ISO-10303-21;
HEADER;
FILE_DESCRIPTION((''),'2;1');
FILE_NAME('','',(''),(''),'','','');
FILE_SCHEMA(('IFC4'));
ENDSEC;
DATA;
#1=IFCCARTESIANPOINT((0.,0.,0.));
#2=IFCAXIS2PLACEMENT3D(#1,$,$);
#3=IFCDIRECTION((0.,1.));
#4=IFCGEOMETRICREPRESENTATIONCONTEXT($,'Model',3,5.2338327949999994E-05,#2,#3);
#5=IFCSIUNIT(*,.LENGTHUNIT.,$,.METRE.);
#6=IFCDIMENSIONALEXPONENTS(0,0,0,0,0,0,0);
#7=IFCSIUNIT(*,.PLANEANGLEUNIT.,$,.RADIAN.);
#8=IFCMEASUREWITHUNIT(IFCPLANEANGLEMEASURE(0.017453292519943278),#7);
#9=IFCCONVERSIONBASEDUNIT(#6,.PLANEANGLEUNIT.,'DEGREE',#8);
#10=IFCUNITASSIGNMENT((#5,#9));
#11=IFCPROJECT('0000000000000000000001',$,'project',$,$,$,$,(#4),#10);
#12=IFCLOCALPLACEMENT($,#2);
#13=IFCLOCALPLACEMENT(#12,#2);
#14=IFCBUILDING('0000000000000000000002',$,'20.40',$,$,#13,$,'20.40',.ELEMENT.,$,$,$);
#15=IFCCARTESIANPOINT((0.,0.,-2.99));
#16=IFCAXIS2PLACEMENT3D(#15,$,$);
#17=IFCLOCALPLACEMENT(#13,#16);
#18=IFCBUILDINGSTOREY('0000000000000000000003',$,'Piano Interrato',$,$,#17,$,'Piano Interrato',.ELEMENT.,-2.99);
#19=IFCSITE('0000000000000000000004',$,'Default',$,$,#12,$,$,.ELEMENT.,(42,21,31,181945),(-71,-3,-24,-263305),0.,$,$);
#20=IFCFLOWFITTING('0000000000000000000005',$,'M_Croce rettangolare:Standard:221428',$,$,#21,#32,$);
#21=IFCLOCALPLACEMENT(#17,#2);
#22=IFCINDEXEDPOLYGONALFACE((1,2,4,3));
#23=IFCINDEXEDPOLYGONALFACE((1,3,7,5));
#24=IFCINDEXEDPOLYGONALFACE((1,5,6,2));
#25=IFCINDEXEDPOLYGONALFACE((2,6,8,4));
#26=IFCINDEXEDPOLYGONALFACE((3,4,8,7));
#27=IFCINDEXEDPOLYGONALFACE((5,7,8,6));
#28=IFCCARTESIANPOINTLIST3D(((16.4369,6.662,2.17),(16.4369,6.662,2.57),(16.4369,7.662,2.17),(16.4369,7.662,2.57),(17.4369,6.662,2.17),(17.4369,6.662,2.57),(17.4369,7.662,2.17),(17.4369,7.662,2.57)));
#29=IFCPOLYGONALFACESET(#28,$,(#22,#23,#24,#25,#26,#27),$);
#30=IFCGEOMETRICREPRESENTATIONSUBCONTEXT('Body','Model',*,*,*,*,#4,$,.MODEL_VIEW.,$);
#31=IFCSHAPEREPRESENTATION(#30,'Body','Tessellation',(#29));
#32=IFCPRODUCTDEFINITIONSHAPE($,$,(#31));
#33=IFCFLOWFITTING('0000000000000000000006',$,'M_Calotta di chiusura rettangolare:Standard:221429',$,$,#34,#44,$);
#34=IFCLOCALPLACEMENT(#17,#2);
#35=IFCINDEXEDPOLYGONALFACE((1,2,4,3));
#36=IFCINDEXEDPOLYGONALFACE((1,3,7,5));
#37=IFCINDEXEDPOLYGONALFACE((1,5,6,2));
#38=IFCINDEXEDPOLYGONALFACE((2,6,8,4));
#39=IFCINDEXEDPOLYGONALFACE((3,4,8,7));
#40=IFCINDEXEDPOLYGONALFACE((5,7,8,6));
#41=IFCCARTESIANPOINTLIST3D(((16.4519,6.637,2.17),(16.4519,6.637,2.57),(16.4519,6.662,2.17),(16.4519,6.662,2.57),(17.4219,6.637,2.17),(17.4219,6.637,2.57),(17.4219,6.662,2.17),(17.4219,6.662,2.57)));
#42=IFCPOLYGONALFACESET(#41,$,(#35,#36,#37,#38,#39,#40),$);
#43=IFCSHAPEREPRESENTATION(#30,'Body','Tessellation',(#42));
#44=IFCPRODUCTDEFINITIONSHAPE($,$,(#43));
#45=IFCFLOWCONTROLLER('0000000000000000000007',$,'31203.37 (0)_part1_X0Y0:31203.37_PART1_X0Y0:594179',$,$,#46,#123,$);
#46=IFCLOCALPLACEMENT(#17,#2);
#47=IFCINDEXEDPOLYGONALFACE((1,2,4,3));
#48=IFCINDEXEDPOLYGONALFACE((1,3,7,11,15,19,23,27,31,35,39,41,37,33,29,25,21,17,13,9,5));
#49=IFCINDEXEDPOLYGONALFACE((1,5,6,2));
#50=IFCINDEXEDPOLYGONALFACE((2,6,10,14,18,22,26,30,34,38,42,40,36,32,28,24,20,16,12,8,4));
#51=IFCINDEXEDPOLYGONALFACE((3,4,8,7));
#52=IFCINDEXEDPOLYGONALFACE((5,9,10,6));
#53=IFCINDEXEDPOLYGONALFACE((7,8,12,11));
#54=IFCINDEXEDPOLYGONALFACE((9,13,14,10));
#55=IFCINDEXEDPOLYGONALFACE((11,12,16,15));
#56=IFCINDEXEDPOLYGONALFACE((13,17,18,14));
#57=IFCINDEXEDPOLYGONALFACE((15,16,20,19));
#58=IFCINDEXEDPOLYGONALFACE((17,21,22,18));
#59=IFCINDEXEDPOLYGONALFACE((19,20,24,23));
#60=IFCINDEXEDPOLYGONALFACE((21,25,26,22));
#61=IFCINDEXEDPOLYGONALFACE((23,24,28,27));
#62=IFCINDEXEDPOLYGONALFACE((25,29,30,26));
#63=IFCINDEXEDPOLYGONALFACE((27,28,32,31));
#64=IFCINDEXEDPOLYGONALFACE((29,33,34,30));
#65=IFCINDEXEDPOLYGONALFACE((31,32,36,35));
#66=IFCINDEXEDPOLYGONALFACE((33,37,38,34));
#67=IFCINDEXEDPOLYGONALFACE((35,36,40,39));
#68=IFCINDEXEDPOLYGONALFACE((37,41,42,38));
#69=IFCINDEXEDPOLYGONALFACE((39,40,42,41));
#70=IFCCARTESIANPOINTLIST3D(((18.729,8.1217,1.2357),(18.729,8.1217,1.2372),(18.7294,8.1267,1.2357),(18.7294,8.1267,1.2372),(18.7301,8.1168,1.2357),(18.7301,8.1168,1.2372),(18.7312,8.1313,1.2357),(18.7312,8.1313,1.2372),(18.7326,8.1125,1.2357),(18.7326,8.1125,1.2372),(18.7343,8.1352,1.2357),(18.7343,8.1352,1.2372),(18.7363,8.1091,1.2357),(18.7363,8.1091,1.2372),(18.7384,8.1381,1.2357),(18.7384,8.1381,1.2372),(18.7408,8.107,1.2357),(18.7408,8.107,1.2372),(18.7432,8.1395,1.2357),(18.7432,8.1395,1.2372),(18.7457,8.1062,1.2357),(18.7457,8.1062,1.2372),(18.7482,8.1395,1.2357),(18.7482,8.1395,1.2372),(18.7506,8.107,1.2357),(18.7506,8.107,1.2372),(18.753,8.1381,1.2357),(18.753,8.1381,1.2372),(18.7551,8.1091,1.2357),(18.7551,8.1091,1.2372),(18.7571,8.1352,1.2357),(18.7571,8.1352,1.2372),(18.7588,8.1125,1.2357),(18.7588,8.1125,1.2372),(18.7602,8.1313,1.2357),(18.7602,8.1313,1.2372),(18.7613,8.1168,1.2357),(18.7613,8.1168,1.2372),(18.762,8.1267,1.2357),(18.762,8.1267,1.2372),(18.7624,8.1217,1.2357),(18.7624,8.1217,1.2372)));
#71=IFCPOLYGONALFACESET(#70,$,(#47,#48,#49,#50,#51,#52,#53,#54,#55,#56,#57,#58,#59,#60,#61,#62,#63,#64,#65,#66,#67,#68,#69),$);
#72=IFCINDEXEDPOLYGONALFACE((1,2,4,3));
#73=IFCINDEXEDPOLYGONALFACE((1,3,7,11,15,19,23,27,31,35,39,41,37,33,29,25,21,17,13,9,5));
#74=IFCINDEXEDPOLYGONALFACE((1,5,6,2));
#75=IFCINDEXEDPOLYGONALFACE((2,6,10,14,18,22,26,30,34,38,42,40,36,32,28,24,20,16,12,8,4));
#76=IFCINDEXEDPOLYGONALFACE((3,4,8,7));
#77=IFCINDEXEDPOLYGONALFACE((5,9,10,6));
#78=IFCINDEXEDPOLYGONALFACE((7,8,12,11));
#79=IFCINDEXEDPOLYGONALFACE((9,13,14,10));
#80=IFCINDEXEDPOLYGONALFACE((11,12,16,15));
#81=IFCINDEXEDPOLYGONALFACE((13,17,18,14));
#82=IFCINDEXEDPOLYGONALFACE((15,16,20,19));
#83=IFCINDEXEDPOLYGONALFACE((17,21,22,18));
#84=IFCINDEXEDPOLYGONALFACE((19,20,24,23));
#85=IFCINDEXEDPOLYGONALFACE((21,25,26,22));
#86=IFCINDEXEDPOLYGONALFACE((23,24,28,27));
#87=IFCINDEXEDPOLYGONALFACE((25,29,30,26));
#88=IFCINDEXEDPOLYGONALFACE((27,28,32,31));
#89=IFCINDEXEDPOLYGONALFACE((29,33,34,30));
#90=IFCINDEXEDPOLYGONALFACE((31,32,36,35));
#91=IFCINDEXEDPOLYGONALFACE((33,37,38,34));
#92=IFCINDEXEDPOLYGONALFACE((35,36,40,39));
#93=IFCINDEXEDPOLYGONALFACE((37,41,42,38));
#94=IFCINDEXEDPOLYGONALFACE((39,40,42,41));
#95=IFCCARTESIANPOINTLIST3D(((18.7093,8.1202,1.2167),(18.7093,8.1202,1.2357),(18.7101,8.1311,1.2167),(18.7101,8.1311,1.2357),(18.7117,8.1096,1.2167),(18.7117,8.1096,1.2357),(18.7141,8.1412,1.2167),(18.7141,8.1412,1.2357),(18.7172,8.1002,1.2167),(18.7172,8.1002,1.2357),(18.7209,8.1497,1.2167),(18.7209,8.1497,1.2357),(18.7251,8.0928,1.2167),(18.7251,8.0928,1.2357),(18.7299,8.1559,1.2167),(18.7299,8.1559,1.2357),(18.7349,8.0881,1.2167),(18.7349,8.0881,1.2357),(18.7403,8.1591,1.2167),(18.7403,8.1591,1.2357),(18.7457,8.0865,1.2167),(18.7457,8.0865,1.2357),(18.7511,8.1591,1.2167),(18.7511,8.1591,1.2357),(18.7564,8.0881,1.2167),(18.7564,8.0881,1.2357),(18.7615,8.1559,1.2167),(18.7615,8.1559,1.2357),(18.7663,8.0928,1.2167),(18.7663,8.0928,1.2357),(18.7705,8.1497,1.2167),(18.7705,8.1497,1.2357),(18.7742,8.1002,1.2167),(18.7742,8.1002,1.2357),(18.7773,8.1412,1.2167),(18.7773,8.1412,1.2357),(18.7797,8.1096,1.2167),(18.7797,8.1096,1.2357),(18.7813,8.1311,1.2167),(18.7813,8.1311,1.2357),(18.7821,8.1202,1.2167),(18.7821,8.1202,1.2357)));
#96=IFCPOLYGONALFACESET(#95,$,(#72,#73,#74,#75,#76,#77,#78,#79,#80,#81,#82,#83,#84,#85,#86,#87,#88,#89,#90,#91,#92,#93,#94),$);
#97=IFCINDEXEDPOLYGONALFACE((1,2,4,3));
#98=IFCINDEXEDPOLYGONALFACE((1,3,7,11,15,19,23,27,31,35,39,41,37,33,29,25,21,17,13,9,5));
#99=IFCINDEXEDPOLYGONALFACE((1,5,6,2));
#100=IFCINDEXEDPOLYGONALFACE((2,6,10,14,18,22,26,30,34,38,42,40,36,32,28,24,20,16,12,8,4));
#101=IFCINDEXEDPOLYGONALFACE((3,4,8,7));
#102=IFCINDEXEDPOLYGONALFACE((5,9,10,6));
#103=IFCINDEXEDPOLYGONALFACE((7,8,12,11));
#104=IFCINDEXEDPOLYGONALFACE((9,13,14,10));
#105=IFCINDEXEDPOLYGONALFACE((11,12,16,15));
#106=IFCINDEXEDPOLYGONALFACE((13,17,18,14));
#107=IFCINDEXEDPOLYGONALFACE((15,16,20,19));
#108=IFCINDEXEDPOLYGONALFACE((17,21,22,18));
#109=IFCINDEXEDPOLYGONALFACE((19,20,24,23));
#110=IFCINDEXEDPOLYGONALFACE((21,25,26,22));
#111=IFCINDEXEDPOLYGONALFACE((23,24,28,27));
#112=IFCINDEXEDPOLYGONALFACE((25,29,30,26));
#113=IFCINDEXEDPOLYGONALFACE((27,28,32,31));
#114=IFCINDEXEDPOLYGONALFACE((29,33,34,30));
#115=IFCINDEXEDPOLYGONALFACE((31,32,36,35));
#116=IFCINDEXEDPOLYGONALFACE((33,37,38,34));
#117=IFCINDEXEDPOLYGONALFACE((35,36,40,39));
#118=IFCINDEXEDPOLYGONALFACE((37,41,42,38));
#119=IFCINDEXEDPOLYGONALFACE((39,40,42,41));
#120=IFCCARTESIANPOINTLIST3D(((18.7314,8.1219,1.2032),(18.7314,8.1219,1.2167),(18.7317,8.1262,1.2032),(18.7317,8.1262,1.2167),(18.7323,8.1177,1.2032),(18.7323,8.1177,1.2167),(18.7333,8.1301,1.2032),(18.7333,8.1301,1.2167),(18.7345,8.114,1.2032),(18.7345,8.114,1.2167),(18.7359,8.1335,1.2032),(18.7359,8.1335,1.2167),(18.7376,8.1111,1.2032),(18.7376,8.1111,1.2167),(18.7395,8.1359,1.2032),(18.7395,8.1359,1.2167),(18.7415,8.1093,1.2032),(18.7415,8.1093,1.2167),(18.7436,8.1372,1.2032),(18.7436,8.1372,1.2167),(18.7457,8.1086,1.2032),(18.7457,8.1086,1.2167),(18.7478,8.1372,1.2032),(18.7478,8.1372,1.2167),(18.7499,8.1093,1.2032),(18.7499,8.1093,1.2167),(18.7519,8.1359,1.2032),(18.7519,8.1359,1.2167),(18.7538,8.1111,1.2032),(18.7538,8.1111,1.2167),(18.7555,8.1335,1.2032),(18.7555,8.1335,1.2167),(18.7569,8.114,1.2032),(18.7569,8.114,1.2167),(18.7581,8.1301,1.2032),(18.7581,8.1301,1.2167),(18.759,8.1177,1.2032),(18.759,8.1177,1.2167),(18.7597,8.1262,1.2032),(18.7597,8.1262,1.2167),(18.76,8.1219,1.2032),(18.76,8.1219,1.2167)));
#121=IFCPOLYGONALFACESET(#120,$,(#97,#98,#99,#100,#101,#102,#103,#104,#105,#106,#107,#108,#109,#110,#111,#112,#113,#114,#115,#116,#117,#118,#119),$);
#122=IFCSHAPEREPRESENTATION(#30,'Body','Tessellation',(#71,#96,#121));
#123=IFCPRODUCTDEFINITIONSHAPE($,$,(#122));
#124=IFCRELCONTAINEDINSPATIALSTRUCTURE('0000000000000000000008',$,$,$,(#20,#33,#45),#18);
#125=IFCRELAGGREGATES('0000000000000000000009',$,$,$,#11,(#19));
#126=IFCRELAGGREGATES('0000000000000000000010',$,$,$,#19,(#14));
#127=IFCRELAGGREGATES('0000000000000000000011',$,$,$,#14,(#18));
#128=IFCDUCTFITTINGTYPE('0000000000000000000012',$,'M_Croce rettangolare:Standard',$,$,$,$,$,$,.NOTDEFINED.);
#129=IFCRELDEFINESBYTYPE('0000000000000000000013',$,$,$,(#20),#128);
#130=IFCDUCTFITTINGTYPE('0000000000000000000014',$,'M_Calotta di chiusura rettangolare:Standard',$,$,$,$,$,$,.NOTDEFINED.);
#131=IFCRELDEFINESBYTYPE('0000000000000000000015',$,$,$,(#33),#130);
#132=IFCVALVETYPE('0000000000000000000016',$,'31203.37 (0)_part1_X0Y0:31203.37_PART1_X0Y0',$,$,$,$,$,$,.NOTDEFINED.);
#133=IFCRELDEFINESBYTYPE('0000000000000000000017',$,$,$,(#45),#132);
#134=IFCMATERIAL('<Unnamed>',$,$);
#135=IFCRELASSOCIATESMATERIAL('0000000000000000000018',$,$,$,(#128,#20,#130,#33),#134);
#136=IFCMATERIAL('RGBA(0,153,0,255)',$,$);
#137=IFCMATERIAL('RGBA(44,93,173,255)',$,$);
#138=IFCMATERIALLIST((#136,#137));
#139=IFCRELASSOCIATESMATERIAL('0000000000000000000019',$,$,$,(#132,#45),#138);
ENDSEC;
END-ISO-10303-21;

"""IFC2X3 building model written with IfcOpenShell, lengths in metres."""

from ifc_helpers import new_model, entity, si_unit, converted_unit, direction, frame, frame_2d, origin, place, context, subcontext, project, spatial, rectangle, circle, extrude, source, transform, mapped, material, material_list, type_object, type_shapes, element, save


model = new_model("IFC2X3")

# Units and contexts
model_context = context("Model", 3, precision=5.2338327949999994e-05, world=origin(), true_north=direction((0.0, 1.0)))
body_context = subcontext(model_context, "Body", "Model", "MODEL_VIEW")
ifc_project = project(units=[si_unit("LENGTHUNIT", "METRE"), converted_unit("PLANEANGLEUNIT", "DEGREE", entity("IfcPlaneAngleMeasure", 0.017453292519943278), si_unit("PLANEANGLEUNIT", "RADIAN"), dimensions=[0, 0, 0, 0, 0, 0, 0])], contexts=[model_context])

# Site, building, storey
site_placement = place(None, origin())
site = spatial("IfcSite", under=ifc_project, at=site_placement, Name="Default", CompositionType="ELEMENT", RefLatitude=(42, 21, 31, 181945), RefLongitude=(-71, -3, -24, -263305), RefElevation=0.0)
building_placement = place(site_placement, origin())
building = spatial("IfcBuilding", under=site, at=building_placement, Name="20.40", LongName="20.40", CompositionType="ELEMENT")
storey_placement = place(building_placement, frame((0.0, 0.0, -2.99)))
storey = spatial("IfcBuildingStorey", under=building, at=storey_placement, Name="Piano Interrato", LongName="Piano Interrato", CompositionType="ELEMENT", Elevation=-2.99)

# Flow fittings
ifc_material_1 = material(Name="<Unnamed>")
duct_fitting_type_1 = type_object("IfcDuctFittingType", Name="M_Croce rettangolare:Standard", PredefinedType="NOTDEFINED", material=ifc_material_1)
shared_shape_1 = source(origin(), body_context, "Body", "SweptSolid", [
    extrude(rectangle(XDim=1.0, YDim=1.0, at=frame_2d((0.0, 0.0), x_axis=(1.0, 0.0))), frame((0.0, 0.0, -0.2), z_axis=(0.0, 0.0, 1.0), x_axis=(0.0, 1.0, 0.0)), (0.0, 0.0, 1.0), 0.4),
])
type_shapes(duct_fitting_type_1, [shared_shape_1])
flow_fitting_1_placement = place(storey_placement, frame((16.9369, 7.162, 2.37), z_axis=(0.0, 0.0, -1.0), x_axis=(-1.0, 0.0, 0.0)))
element("IfcFlowFitting", 1, at=flow_fitting_1_placement, inside=storey, type_object=duct_fitting_type_1, material=ifc_material_1, Name="M_Croce rettangolare:Standard:221428", context=body_context, shape_type="MappedRepresentation", body=[
    mapped(shared_shape_1, transform((0.0, 0.0, 0.0), scale=1.0)),
])
duct_fitting_type_2 = type_object("IfcDuctFittingType", Name="M_Calotta di chiusura rettangolare:Standard", PredefinedType="NOTDEFINED", material=ifc_material_1)
shared_shape_2 = source(origin(), body_context, "Body", "SweptSolid", [
    extrude(rectangle(XDim=0.025, YDim=0.97, at=frame_2d((0.0, 0.0), x_axis=(1.0, 0.0))), frame((0.0125, 0.0, -0.2)), (0.0, 0.0, 1.0), 0.4),
])
type_shapes(duct_fitting_type_2, [shared_shape_2])
flow_fitting_2_placement = place(storey_placement, frame((16.9369, 6.662, 2.37), z_axis=(0.0, 0.0, 1.0), x_axis=(0.0, -1.0, 0.0)))
element("IfcFlowFitting", 2, at=flow_fitting_2_placement, inside=storey, type_object=duct_fitting_type_2, material=ifc_material_1, Name="M_Calotta di chiusura rettangolare:Standard:221429", context=body_context, shape_type="MappedRepresentation", body=[
    mapped(shared_shape_2, transform((0.0, 0.0, 0.0), scale=1.0)),
])

# Flow controller
ifc_material_2 = material(Name="RGBA(0,153,0,255)")
ifc_material_3 = material(Name="RGBA(44,93,173,255)")
ifc_material_list_1 = material_list([ifc_material_2, ifc_material_3])
valve_type_1 = type_object("IfcValveType", Name="31203.37 (0)_part1_X0Y0:31203.37_PART1_X0Y0", PredefinedType="NOTDEFINED", material=ifc_material_list_1)
shared_shape_3 = source(origin(), body_context, "Body", "SweptSolid", [
    extrude(circle(Radius=0.0168, at=frame_2d((0.0, 0.0), x_axis=(1.0, 0.0))), frame((0.0, 0.0, 0.0325), z_axis=(0.0, 0.0, 1.0), x_axis=(0.0, -1.0, 0.0)), (0.0, 0.0, 1.0), 0.0015),
    extrude(circle(Radius=0.0365, at=frame_2d((0.0, 0.0), x_axis=(1.0, 0.0))), frame((0.0, 0.0, 0.0135), z_axis=(0.0, 0.0, 1.0), x_axis=(0.0, -1.0, 0.0)), (0.0, 0.0, 1.0), 0.019),
    extrude(circle(Radius=0.0144, at=frame_2d((0.0, 0.0), x_axis=(1.0, 0.0))), frame((0.0, 0.0, 0.0), z_axis=(0.0, 0.0, 1.0), x_axis=(0.0, -1.0, 0.0)), (0.0, 0.0, 1.0), 0.0135),
])
type_shapes(valve_type_1, [shared_shape_3])
flow_controller_1_placement = place(storey_placement, frame((18.7457, 8.123, 1.2032)))
element("IfcFlowController", 3, at=flow_controller_1_placement, inside=storey, type_object=valve_type_1, material=ifc_material_list_1, Name="31203.37 (0)_part1_X0Y0:31203.37_PART1_X0Y0:594179", context=body_context, shape_type="MappedRepresentation", body=[
    mapped(shared_shape_3, transform((0.0, 0.0, 0.0), scale=1.0)),
])

save(model, "model.ifc")
